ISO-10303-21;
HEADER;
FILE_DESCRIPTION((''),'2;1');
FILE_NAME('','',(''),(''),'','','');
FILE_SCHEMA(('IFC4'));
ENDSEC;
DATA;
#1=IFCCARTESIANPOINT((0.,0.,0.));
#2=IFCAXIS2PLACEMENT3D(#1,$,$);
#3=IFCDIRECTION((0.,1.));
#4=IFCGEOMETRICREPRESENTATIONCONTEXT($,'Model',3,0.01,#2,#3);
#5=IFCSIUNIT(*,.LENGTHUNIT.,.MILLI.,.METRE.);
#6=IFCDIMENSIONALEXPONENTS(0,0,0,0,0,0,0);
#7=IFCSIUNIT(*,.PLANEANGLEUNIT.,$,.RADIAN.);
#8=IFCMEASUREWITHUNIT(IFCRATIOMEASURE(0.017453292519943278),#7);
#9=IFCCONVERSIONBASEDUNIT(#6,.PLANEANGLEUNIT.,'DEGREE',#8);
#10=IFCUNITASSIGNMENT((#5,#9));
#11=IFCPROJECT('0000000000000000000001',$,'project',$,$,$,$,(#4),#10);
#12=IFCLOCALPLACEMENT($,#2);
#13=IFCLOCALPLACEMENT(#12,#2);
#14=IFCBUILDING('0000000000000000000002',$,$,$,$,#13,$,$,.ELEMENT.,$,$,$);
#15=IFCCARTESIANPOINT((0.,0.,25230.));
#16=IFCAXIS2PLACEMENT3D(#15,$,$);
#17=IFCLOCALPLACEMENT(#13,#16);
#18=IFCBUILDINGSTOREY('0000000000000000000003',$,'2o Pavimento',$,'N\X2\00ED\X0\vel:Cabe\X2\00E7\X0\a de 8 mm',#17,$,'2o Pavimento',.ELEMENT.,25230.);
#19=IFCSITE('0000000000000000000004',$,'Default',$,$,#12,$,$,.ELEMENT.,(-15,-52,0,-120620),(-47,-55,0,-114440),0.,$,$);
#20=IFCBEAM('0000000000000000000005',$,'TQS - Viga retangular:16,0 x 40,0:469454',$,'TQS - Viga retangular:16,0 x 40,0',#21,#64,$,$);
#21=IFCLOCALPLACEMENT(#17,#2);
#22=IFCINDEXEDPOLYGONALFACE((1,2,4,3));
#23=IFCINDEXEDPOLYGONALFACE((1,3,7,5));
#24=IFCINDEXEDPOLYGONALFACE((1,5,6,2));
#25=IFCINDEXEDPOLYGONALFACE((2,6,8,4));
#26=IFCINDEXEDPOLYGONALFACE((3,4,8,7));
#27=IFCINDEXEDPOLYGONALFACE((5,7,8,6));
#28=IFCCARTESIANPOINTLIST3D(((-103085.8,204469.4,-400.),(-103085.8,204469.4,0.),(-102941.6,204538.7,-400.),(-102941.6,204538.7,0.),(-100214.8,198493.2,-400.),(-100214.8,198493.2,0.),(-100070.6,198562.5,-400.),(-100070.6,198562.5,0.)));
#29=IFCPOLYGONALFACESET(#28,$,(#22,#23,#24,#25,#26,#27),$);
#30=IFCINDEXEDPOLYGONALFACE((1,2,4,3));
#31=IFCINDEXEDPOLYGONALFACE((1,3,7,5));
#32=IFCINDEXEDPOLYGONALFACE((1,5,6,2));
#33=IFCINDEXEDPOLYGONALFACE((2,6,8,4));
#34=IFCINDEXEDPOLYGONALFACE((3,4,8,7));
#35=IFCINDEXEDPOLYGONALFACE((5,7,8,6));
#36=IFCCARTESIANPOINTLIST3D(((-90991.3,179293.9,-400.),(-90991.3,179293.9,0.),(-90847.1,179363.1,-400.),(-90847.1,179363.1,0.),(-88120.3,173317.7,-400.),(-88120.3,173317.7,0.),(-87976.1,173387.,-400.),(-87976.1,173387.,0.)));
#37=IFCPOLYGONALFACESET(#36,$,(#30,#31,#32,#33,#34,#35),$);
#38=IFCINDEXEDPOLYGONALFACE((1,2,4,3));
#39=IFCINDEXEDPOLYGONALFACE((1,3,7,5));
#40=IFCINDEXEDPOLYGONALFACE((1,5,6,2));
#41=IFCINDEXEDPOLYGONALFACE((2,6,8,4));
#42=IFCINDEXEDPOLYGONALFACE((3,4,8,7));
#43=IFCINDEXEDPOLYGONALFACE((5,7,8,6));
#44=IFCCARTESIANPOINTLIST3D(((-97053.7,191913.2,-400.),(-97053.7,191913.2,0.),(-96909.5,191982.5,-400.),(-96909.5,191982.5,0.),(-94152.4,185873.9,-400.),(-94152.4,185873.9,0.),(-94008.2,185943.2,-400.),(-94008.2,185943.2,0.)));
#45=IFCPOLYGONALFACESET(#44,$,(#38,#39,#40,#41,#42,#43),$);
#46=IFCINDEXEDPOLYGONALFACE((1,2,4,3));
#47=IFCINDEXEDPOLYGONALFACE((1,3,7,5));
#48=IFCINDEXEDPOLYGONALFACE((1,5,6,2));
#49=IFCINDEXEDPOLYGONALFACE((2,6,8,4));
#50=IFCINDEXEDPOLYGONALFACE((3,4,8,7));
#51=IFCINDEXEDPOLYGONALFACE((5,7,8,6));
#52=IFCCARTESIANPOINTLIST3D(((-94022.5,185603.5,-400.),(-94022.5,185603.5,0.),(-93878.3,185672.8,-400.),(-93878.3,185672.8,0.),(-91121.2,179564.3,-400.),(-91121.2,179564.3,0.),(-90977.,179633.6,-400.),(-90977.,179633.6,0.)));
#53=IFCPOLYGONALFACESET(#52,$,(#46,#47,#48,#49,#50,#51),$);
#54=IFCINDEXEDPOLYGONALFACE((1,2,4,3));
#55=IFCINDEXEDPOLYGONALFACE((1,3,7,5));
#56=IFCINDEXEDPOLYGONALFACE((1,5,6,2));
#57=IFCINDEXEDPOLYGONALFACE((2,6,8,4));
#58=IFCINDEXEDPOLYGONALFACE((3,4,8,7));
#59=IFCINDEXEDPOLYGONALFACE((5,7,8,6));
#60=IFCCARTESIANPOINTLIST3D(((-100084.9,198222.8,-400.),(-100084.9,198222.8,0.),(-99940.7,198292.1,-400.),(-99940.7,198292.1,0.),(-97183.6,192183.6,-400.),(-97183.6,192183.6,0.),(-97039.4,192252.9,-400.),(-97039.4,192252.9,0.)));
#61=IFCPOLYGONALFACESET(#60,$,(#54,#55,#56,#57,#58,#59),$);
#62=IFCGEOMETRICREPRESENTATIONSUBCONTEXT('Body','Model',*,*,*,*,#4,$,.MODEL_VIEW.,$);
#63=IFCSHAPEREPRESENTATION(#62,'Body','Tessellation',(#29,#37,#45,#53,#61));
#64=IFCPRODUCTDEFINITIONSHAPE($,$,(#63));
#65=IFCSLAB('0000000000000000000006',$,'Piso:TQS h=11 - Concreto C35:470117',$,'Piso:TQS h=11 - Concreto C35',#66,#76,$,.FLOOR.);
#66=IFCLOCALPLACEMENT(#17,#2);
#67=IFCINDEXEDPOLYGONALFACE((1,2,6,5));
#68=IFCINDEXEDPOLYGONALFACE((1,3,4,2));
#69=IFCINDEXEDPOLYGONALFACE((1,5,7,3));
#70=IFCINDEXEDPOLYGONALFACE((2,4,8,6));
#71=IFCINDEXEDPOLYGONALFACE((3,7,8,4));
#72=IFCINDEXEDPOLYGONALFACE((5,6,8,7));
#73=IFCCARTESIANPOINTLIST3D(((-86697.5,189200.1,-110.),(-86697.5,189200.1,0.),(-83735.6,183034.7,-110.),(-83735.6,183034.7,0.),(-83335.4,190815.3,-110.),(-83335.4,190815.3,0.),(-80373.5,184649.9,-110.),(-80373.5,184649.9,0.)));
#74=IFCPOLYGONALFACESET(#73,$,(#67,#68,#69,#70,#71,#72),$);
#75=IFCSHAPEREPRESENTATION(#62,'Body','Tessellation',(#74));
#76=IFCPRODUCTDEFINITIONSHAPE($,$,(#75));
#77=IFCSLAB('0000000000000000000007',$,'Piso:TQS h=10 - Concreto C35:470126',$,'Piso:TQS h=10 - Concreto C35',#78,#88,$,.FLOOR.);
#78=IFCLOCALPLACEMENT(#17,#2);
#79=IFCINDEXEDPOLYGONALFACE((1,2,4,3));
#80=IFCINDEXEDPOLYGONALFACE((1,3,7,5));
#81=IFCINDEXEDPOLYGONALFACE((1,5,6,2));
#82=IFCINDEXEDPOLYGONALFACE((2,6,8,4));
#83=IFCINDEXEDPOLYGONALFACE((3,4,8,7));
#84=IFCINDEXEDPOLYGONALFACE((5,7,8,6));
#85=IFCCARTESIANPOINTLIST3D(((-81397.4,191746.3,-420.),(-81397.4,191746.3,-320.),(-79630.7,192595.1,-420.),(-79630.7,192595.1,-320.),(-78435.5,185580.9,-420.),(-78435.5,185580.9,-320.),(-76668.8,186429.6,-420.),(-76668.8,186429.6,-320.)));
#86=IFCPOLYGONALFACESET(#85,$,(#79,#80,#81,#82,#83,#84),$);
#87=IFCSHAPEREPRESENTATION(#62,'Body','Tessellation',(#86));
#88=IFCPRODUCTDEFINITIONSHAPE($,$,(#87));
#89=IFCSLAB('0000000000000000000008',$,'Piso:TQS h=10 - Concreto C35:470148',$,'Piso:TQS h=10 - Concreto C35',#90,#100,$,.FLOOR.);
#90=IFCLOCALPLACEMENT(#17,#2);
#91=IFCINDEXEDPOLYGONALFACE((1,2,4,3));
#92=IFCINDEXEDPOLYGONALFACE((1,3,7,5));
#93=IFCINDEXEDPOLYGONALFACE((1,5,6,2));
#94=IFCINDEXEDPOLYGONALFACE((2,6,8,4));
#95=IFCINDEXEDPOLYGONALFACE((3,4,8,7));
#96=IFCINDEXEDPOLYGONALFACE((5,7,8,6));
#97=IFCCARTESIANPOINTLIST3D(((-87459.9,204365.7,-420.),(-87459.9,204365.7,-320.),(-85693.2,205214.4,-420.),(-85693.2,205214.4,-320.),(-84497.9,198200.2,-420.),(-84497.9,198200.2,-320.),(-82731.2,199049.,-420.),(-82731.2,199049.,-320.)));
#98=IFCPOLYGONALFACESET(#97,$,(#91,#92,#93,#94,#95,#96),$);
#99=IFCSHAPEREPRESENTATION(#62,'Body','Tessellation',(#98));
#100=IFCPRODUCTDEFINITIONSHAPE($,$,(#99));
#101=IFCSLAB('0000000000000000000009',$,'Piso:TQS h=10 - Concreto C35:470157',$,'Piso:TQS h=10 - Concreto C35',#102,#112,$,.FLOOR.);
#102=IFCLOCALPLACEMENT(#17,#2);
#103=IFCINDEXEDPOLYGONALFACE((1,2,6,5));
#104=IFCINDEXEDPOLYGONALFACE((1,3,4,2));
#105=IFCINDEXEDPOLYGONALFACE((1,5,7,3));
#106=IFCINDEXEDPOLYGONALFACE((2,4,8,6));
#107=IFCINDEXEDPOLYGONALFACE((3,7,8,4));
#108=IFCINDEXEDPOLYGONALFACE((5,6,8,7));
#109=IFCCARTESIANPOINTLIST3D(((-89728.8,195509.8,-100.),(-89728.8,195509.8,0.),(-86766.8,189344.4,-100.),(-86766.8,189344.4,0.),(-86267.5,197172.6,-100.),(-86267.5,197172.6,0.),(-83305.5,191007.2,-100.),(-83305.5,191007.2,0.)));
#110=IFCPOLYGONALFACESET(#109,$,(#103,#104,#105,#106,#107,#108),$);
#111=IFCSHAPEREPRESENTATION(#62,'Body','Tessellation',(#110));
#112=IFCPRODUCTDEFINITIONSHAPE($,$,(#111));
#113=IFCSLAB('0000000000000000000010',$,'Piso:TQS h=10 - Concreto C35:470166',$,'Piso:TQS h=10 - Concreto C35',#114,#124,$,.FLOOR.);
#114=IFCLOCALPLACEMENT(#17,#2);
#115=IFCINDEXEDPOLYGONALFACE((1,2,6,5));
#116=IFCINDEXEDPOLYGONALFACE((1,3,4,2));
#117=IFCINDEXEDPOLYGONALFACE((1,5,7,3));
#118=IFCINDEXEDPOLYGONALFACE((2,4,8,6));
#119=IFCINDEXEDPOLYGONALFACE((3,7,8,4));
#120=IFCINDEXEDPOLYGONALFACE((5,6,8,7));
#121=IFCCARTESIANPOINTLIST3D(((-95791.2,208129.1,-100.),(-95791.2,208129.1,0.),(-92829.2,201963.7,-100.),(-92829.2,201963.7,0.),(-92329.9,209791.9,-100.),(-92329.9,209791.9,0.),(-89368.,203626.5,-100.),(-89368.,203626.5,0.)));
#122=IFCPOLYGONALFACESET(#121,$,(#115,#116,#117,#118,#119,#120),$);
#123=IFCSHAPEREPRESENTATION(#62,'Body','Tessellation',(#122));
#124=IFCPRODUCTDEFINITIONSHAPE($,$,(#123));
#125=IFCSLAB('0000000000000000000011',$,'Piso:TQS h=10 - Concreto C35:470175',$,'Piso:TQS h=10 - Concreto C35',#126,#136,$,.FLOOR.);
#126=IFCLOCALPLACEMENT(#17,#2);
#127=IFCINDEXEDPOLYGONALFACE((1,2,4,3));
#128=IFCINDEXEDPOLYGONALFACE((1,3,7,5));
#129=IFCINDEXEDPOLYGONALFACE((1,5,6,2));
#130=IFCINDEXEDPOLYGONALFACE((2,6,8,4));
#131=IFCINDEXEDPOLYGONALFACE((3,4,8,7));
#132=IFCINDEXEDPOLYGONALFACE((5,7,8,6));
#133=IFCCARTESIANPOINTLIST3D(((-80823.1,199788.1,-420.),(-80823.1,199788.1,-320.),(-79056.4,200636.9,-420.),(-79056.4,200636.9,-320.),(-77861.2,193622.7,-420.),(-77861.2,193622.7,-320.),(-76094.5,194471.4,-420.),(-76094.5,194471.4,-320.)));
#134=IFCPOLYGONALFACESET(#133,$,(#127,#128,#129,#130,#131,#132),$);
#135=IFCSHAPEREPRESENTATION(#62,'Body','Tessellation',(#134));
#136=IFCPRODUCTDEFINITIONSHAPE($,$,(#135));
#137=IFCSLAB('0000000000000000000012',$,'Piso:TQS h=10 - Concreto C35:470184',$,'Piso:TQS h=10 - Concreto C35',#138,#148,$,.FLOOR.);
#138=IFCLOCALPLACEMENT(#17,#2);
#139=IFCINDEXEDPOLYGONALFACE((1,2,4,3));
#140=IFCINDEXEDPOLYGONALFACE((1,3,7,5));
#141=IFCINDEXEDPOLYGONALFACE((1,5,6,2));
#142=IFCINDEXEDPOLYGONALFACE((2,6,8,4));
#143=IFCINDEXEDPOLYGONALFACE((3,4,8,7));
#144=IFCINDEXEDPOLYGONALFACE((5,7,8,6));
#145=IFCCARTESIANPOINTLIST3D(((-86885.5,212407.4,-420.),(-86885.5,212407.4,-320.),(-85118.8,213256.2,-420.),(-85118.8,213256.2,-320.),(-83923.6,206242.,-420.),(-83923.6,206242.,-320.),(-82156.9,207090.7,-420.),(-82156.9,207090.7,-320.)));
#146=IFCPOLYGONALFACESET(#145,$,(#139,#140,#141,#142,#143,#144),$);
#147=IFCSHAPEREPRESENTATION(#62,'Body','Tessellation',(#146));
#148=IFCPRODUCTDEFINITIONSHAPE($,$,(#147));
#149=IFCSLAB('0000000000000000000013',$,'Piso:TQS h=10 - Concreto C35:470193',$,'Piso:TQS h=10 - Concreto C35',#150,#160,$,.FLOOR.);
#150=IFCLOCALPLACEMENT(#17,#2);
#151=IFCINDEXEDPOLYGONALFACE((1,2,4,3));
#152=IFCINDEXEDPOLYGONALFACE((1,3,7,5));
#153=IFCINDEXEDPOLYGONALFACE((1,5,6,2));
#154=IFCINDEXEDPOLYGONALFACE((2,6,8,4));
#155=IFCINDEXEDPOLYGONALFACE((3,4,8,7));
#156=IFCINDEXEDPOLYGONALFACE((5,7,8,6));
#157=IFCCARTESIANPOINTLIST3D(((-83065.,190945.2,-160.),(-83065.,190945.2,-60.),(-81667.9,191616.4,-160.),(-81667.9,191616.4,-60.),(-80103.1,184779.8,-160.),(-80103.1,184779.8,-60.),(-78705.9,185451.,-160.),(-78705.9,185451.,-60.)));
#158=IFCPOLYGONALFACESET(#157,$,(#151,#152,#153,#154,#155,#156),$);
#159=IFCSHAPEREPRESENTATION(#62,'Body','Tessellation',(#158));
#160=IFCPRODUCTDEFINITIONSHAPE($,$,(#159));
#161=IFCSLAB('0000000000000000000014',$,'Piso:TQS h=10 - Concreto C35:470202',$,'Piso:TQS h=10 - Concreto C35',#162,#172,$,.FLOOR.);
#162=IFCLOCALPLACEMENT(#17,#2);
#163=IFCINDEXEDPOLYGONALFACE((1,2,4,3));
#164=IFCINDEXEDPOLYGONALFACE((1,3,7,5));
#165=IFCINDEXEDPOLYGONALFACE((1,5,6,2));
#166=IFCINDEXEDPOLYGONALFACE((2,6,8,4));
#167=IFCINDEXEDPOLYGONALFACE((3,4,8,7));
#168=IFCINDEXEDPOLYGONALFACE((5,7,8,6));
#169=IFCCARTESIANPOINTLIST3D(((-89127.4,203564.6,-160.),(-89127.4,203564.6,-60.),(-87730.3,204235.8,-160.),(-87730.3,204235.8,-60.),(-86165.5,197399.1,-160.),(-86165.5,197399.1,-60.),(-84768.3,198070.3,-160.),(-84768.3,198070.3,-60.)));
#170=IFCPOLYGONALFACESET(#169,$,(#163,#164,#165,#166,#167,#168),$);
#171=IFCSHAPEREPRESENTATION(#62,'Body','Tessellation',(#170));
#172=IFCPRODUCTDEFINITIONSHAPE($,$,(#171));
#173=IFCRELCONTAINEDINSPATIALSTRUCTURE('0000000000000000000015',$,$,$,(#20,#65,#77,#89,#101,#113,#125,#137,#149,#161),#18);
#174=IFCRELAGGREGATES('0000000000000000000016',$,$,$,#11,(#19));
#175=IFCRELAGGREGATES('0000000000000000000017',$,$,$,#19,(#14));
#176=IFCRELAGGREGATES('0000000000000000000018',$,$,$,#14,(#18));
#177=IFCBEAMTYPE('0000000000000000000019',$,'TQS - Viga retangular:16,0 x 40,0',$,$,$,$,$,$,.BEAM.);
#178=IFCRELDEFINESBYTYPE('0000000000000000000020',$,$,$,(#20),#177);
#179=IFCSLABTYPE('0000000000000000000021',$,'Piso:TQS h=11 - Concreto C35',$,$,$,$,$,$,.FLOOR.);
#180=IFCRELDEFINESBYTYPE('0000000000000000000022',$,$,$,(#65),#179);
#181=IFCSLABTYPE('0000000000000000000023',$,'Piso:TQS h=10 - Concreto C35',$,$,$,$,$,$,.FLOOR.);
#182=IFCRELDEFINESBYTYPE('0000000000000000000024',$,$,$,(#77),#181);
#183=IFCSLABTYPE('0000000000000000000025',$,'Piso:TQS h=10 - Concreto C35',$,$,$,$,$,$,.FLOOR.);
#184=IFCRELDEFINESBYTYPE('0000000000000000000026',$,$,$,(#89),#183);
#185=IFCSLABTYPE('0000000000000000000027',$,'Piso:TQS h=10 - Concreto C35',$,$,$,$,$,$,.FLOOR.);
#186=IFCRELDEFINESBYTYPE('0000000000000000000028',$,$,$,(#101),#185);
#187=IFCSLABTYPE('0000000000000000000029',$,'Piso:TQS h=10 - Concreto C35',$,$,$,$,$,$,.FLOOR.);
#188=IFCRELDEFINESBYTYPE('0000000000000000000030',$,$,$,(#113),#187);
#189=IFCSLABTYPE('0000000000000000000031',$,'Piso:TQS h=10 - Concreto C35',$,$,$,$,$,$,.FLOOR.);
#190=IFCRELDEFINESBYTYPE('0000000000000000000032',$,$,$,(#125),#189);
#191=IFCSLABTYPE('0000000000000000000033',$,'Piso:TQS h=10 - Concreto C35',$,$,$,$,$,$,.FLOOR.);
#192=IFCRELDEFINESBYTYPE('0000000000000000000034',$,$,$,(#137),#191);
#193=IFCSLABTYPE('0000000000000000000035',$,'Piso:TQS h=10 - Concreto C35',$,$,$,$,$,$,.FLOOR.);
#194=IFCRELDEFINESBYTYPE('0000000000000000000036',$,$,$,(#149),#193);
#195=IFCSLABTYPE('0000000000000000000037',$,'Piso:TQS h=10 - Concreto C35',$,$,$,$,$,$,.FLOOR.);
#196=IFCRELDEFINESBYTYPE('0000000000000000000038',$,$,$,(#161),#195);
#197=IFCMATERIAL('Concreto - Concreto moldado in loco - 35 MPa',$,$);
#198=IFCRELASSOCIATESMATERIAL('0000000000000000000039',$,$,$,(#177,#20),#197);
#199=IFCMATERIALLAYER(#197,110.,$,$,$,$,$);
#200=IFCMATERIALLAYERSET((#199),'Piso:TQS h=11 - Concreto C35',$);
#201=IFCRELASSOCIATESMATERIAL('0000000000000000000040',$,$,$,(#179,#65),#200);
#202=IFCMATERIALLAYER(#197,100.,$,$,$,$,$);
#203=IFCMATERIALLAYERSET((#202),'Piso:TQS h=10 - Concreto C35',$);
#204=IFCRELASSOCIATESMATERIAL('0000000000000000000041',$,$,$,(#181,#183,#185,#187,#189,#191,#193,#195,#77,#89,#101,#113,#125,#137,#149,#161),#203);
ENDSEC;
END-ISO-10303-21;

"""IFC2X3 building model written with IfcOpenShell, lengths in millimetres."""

from ifc_helpers import new_model, entity, si_unit, converted_unit, direction, frame, frame_2d, origin, place, context, subcontext, project, spatial, rectangle, extrude, source, transform, mapped, material, layer, layer_set, layer_usage, type_object, type_shapes, element, save


model = new_model("IFC2X3")

# Units and contexts
model_context = context("Model", 3, precision=0.01, world=origin(), true_north=direction((0.0, 1.0)))
body_context = subcontext(model_context, "Body", "Model", "MODEL_VIEW")
ifc_project = project(units=[si_unit("LENGTHUNIT", "METRE", prefix="MILLI"), converted_unit("PLANEANGLEUNIT", "DEGREE", entity("IfcRatioMeasure", 0.017453292519943278), si_unit("PLANEANGLEUNIT", "RADIAN"), dimensions=[0, 0, 0, 0, 0, 0, 0])], contexts=[model_context])

# Site, building, storey
site_placement = place(None, origin())
site = spatial("IfcSite", under=ifc_project, at=site_placement, Name="Default", CompositionType="ELEMENT", RefLatitude=(-15, -52, 0, -120620), RefLongitude=(-47, -55, 0, -114440), RefElevation=0.0)
building_placement = place(site_placement, origin())
building = spatial("IfcBuilding", under=site, at=building_placement, CompositionType="ELEMENT")
storey_placement = place(building_placement, frame((0.0, 0.0, 25230.0)))
storey = spatial("IfcBuildingStorey", under=building, at=storey_placement, Name="2o Pavimento", ObjectType="Nível:Cabeça de 8 mm", LongName="2o Pavimento", CompositionType="ELEMENT", Elevation=25230.0)

# Beam
ifc_material = material(Name="Concreto - Concreto moldado in loco - 35 MPa")
beam_type = type_object("IfcBeamType", Name="TQS - Viga retangular:16,0 x 40,0", PredefinedType="BEAM", material=ifc_material)
shared_shape = source(origin(), body_context, "Body", "SweptSolid", [
    extrude(rectangle(XDim=400.0, YDim=160.0, at=frame_2d((0.0, 0.0), x_axis=(1.0, 0.0))), frame((-100142.7, 198527.9, 25030.0), z_axis=(-0.43303, 0.90138, 0.0), x_axis=(0.0, 0.0, 1.0)), (0.0, 0.0, 1.0), 6630.0),
    extrude(rectangle(XDim=400.0, YDim=160.0, at=frame_2d((0.0, 0.0), x_axis=(1.0, 0.0))), frame((-88048.2, 173352.3, 25030.0), z_axis=(-0.43303, 0.90138, 0.0), x_axis=(0.0, 0.0, 1.0)), (0.0, 0.0, 1.0), 6630.0),
    extrude(rectangle(XDim=400.0, YDim=160.0, at=frame_2d((0.0, 0.0), x_axis=(1.0, 0.0))), frame((-94080.3, 185908.6, 25030.0), z_axis=(-0.43303, 0.90138, 0.0), x_axis=(0.0, 0.0, 1.0)), (0.0, 0.0, 1.0), 6700.0),
    extrude(rectangle(XDim=400.0, YDim=160.0, at=frame_2d((0.0, 0.0), x_axis=(1.0, 0.0))), frame((-91049.1, 179598.9, 25030.0), z_axis=(-0.43303, 0.90138, 0.0), x_axis=(0.0, 0.0, 1.0)), (0.0, 0.0, 1.0), 6700.0),
    extrude(rectangle(XDim=400.0, YDim=160.0, at=frame_2d((0.0, 0.0), x_axis=(1.0, 0.0))), frame((-97111.5, 192218.2, 25030.0), z_axis=(-0.43303, 0.90138, 0.0), x_axis=(0.0, 0.0, 1.0)), (0.0, 0.0, 1.0), 6700.0),
])
type_shapes(beam_type, [shared_shape])
beam_placement = place(storey_placement, frame((0.0, 0.0, -25230.0)))
element("IfcBeam", 1, at=beam_placement, inside=storey, type_object=beam_type, material=ifc_material, Name="TQS - Viga retangular:16,0 x 40,0:469454", ObjectType="TQS - Viga retangular:16,0 x 40,0", context=body_context, shape_type="MappedRepresentation", body=[
    mapped(shared_shape, transform((0.0, 0.0, 0.0), scale=1.0)),
])

# Slabs
ifc_layer_1 = layer(ifc_material, 110.0)
ifc_layer_set_1 = layer_set([ifc_layer_1], Name="Piso:TQS h=11 - Concreto C35")
ifc_layer_usage_1 = layer_usage(ifc_layer_set_1, "AXIS3", "POSITIVE", 0.0)
slab_type_1 = type_object("IfcSlabType", Name="Piso:TQS h=11 - Concreto C35", PredefinedType="FLOOR", material=ifc_layer_set_1)
slab_1_placement = place(storey_placement, origin())
element("IfcSlab", 2, at=slab_1_placement, inside=storey, type_object=slab_type_1, material=ifc_layer_usage_1, Name="Piso:TQS h=11 - Concreto C35:470117", ObjectType="Piso:TQS h=11 - Concreto C35", PredefinedType="FLOOR", context=body_context, shape_type="SweptSolid", body=[
    extrude(rectangle(XDim=6840.0, YDim=3730.0, at=frame_2d((0.0, 0.0), x_axis=(1.0, 0.0))), frame((-83535.5, 186925.0, 0.0), z_axis=(0.0, 0.0, -1.0), x_axis=(0.43303, -0.90138, 0.0)), (0.0, 0.0, 1.0), 110.0),
])
ifc_layer_2 = layer(ifc_material, 100.0)
ifc_layer_set_2 = layer_set([ifc_layer_2], Name="Piso:TQS h=10 - Concreto C35")
ifc_layer_usage_2 = layer_usage(ifc_layer_set_2, "AXIS3", "POSITIVE", 0.0)
slab_type_2 = type_object("IfcSlabType", Name="Piso:TQS h=10 - Concreto C35", PredefinedType="FLOOR", material=ifc_layer_set_2)
slab_2_placement = place(storey_placement, origin())
element("IfcSlab", 3, at=slab_2_placement, inside=storey, type_object=slab_type_2, material=ifc_layer_usage_2, Name="Piso:TQS h=10 - Concreto C35:470126", ObjectType="Piso:TQS h=10 - Concreto C35", PredefinedType="FLOOR", context=body_context, shape_type="SweptSolid", body=[
    extrude(rectangle(XDim=6840.0, YDim=1960.0, at=frame_2d((0.0, 0.0), x_axis=(1.0, 0.0))), frame((-79033.1, 189088.0, -320.0), z_axis=(0.0, 0.0, -1.0), x_axis=(0.43303, -0.90138, 0.0)), (0.0, 0.0, 1.0), 100.0),
])
ifc_layer_usage_3 = layer_usage(ifc_layer_set_2, "AXIS3", "POSITIVE", 0.0)
slab_type_3 = type_object("IfcSlabType", Name="Piso:TQS h=10 - Concreto C35", PredefinedType="FLOOR", material=ifc_layer_set_2)
slab_3_placement = place(storey_placement, origin())
element("IfcSlab", 4, at=slab_3_placement, inside=storey, type_object=slab_type_3, material=ifc_layer_usage_3, Name="Piso:TQS h=10 - Concreto C35:470148", ObjectType="Piso:TQS h=10 - Concreto C35", PredefinedType="FLOOR", context=body_context, shape_type="SweptSolid", body=[
    extrude(rectangle(XDim=6840.0, YDim=1960.0, at=frame_2d((0.0, 0.0), x_axis=(1.0, 0.0))), frame((-85095.5, 201707.3, -320.0), z_axis=(0.0, 0.0, -1.0), x_axis=(0.43303, -0.90138, 0.0)), (0.0, 0.0, 1.0), 100.0),
])
ifc_layer_usage_4 = layer_usage(ifc_layer_set_2, "AXIS3", "POSITIVE", 0.0)
slab_type_4 = type_object("IfcSlabType", Name="Piso:TQS h=10 - Concreto C35", PredefinedType="FLOOR", material=ifc_layer_set_2)
slab_4_placement = place(storey_placement, origin())
element("IfcSlab", 5, at=slab_4_placement, inside=storey, type_object=slab_type_4, material=ifc_layer_usage_4, Name="Piso:TQS h=10 - Concreto C35:470157", ObjectType="Piso:TQS h=10 - Concreto C35", PredefinedType="FLOOR", context=body_context, shape_type="SweptSolid", body=[
    extrude(rectangle(XDim=6840.0, YDim=3840.0, at=frame_2d((0.0, 0.0), x_axis=(1.0, 0.0))), frame((-86517.1, 193258.5, 0.0), z_axis=(0.0, 0.0, -1.0), x_axis=(0.43303, -0.90138, 0.0)), (0.0, 0.0, 1.0), 100.0),
])
ifc_layer_usage_5 = layer_usage(ifc_layer_set_2, "AXIS3", "POSITIVE", 0.0)
slab_type_5 = type_object("IfcSlabType", Name="Piso:TQS h=10 - Concreto C35", PredefinedType="FLOOR", material=ifc_layer_set_2)
slab_5_placement = place(storey_placement, origin())
element("IfcSlab", 6, at=slab_5_placement, inside=storey, type_object=slab_type_5, material=ifc_layer_usage_5, Name="Piso:TQS h=10 - Concreto C35:470166", ObjectType="Piso:TQS h=10 - Concreto C35", PredefinedType="FLOOR", context=body_context, shape_type="SweptSolid", body=[
    extrude(rectangle(XDim=6840.0, YDim=3840.0, at=frame_2d((0.0, 0.0), x_axis=(1.0, 0.0))), frame((-92579.6, 205877.8, 0.0), z_axis=(0.0, 0.0, -1.0), x_axis=(0.43303, -0.90138, 0.0)), (0.0, 0.0, 1.0), 100.0),
])
ifc_layer_usage_6 = layer_usage(ifc_layer_set_2, "AXIS3", "POSITIVE", 0.0)
slab_type_6 = type_object("IfcSlabType", Name="Piso:TQS h=10 - Concreto C35", PredefinedType="FLOOR", material=ifc_layer_set_2)
slab_6_placement = place(storey_placement, origin())
element("IfcSlab", 7, at=slab_6_placement, inside=storey, type_object=slab_type_6, material=ifc_layer_usage_6, Name="Piso:TQS h=10 - Concreto C35:470175", ObjectType="Piso:TQS h=10 - Concreto C35", PredefinedType="FLOOR", context=body_context, shape_type="SweptSolid", body=[
    extrude(rectangle(XDim=6840.0, YDim=1960.0, at=frame_2d((0.0, 0.0), x_axis=(1.0, 0.0))), frame((-78458.8, 197129.8, -320.0), z_axis=(0.0, 0.0, -1.0), x_axis=(0.43303, -0.90138, 0.0)), (0.0, 0.0, 1.0), 100.0),
])
ifc_layer_usage_7 = layer_usage(ifc_layer_set_2, "AXIS3", "POSITIVE", 0.0)
slab_type_7 = type_object("IfcSlabType", Name="Piso:TQS h=10 - Concreto C35", PredefinedType="FLOOR", material=ifc_layer_set_2)
slab_7_placement = place(storey_placement, origin())
element("IfcSlab", 8, at=slab_7_placement, inside=storey, type_object=slab_type_7, material=ifc_layer_usage_7, Name="Piso:TQS h=10 - Concreto C35:470184", ObjectType="Piso:TQS h=10 - Concreto C35", PredefinedType="FLOOR", context=body_context, shape_type="SweptSolid", body=[
    extrude(rectangle(XDim=6840.0, YDim=1960.0, at=frame_2d((0.0, 0.0), x_axis=(1.0, 0.0))), frame((-84521.2, 209749.1, -320.0), z_axis=(0.0, 0.0, -1.0), x_axis=(0.43303, -0.90138, 0.0)), (0.0, 0.0, 1.0), 100.0),
])
ifc_layer_usage_8 = layer_usage(ifc_layer_set_2, "AXIS3", "POSITIVE", 0.0)
slab_type_8 = type_object("IfcSlabType", Name="Piso:TQS h=10 - Concreto C35", PredefinedType="FLOOR", material=ifc_layer_set_2)
slab_8_placement = place(storey_placement, origin())
element("IfcSlab", 9, at=slab_8_placement, inside=storey, type_object=slab_type_8, material=ifc_layer_usage_8, Name="Piso:TQS h=10 - Concreto C35:470193", ObjectType="Piso:TQS h=10 - Concreto C35", PredefinedType="FLOOR", context=body_context, shape_type="SweptSolid", body=[
    extrude(rectangle(XDim=6840.0, YDim=1550.0, at=frame_2d((0.0, 0.0), x_axis=(1.0, 0.0))), frame((-80885.5, 188198.1, -60.0), z_axis=(0.0, 0.0, -1.0), x_axis=(0.43303, -0.90138, 0.0)), (0.0, 0.0, 1.0), 100.0),
])
ifc_layer_usage_9 = layer_usage(ifc_layer_set_2, "AXIS3", "POSITIVE", 0.0)
slab_type_9 = type_object("IfcSlabType", Name="Piso:TQS h=10 - Concreto C35", PredefinedType="FLOOR", material=ifc_layer_set_2)
slab_9_placement = place(storey_placement, origin())
element("IfcSlab", 10, at=slab_9_placement, inside=storey, type_object=slab_type_9, material=ifc_layer_usage_9, Name="Piso:TQS h=10 - Concreto C35:470202", ObjectType="Piso:TQS h=10 - Concreto C35", PredefinedType="FLOOR", context=body_context, shape_type="SweptSolid", body=[
    extrude(rectangle(XDim=6840.0, YDim=1550.0, at=frame_2d((0.0, 0.0), x_axis=(1.0, 0.0))), frame((-86947.9, 200817.4, -60.0), z_axis=(0.0, 0.0, -1.0), x_axis=(0.43303, -0.90138, 0.0)), (0.0, 0.0, 1.0), 100.0),
])

save(model, "model.ifc")
